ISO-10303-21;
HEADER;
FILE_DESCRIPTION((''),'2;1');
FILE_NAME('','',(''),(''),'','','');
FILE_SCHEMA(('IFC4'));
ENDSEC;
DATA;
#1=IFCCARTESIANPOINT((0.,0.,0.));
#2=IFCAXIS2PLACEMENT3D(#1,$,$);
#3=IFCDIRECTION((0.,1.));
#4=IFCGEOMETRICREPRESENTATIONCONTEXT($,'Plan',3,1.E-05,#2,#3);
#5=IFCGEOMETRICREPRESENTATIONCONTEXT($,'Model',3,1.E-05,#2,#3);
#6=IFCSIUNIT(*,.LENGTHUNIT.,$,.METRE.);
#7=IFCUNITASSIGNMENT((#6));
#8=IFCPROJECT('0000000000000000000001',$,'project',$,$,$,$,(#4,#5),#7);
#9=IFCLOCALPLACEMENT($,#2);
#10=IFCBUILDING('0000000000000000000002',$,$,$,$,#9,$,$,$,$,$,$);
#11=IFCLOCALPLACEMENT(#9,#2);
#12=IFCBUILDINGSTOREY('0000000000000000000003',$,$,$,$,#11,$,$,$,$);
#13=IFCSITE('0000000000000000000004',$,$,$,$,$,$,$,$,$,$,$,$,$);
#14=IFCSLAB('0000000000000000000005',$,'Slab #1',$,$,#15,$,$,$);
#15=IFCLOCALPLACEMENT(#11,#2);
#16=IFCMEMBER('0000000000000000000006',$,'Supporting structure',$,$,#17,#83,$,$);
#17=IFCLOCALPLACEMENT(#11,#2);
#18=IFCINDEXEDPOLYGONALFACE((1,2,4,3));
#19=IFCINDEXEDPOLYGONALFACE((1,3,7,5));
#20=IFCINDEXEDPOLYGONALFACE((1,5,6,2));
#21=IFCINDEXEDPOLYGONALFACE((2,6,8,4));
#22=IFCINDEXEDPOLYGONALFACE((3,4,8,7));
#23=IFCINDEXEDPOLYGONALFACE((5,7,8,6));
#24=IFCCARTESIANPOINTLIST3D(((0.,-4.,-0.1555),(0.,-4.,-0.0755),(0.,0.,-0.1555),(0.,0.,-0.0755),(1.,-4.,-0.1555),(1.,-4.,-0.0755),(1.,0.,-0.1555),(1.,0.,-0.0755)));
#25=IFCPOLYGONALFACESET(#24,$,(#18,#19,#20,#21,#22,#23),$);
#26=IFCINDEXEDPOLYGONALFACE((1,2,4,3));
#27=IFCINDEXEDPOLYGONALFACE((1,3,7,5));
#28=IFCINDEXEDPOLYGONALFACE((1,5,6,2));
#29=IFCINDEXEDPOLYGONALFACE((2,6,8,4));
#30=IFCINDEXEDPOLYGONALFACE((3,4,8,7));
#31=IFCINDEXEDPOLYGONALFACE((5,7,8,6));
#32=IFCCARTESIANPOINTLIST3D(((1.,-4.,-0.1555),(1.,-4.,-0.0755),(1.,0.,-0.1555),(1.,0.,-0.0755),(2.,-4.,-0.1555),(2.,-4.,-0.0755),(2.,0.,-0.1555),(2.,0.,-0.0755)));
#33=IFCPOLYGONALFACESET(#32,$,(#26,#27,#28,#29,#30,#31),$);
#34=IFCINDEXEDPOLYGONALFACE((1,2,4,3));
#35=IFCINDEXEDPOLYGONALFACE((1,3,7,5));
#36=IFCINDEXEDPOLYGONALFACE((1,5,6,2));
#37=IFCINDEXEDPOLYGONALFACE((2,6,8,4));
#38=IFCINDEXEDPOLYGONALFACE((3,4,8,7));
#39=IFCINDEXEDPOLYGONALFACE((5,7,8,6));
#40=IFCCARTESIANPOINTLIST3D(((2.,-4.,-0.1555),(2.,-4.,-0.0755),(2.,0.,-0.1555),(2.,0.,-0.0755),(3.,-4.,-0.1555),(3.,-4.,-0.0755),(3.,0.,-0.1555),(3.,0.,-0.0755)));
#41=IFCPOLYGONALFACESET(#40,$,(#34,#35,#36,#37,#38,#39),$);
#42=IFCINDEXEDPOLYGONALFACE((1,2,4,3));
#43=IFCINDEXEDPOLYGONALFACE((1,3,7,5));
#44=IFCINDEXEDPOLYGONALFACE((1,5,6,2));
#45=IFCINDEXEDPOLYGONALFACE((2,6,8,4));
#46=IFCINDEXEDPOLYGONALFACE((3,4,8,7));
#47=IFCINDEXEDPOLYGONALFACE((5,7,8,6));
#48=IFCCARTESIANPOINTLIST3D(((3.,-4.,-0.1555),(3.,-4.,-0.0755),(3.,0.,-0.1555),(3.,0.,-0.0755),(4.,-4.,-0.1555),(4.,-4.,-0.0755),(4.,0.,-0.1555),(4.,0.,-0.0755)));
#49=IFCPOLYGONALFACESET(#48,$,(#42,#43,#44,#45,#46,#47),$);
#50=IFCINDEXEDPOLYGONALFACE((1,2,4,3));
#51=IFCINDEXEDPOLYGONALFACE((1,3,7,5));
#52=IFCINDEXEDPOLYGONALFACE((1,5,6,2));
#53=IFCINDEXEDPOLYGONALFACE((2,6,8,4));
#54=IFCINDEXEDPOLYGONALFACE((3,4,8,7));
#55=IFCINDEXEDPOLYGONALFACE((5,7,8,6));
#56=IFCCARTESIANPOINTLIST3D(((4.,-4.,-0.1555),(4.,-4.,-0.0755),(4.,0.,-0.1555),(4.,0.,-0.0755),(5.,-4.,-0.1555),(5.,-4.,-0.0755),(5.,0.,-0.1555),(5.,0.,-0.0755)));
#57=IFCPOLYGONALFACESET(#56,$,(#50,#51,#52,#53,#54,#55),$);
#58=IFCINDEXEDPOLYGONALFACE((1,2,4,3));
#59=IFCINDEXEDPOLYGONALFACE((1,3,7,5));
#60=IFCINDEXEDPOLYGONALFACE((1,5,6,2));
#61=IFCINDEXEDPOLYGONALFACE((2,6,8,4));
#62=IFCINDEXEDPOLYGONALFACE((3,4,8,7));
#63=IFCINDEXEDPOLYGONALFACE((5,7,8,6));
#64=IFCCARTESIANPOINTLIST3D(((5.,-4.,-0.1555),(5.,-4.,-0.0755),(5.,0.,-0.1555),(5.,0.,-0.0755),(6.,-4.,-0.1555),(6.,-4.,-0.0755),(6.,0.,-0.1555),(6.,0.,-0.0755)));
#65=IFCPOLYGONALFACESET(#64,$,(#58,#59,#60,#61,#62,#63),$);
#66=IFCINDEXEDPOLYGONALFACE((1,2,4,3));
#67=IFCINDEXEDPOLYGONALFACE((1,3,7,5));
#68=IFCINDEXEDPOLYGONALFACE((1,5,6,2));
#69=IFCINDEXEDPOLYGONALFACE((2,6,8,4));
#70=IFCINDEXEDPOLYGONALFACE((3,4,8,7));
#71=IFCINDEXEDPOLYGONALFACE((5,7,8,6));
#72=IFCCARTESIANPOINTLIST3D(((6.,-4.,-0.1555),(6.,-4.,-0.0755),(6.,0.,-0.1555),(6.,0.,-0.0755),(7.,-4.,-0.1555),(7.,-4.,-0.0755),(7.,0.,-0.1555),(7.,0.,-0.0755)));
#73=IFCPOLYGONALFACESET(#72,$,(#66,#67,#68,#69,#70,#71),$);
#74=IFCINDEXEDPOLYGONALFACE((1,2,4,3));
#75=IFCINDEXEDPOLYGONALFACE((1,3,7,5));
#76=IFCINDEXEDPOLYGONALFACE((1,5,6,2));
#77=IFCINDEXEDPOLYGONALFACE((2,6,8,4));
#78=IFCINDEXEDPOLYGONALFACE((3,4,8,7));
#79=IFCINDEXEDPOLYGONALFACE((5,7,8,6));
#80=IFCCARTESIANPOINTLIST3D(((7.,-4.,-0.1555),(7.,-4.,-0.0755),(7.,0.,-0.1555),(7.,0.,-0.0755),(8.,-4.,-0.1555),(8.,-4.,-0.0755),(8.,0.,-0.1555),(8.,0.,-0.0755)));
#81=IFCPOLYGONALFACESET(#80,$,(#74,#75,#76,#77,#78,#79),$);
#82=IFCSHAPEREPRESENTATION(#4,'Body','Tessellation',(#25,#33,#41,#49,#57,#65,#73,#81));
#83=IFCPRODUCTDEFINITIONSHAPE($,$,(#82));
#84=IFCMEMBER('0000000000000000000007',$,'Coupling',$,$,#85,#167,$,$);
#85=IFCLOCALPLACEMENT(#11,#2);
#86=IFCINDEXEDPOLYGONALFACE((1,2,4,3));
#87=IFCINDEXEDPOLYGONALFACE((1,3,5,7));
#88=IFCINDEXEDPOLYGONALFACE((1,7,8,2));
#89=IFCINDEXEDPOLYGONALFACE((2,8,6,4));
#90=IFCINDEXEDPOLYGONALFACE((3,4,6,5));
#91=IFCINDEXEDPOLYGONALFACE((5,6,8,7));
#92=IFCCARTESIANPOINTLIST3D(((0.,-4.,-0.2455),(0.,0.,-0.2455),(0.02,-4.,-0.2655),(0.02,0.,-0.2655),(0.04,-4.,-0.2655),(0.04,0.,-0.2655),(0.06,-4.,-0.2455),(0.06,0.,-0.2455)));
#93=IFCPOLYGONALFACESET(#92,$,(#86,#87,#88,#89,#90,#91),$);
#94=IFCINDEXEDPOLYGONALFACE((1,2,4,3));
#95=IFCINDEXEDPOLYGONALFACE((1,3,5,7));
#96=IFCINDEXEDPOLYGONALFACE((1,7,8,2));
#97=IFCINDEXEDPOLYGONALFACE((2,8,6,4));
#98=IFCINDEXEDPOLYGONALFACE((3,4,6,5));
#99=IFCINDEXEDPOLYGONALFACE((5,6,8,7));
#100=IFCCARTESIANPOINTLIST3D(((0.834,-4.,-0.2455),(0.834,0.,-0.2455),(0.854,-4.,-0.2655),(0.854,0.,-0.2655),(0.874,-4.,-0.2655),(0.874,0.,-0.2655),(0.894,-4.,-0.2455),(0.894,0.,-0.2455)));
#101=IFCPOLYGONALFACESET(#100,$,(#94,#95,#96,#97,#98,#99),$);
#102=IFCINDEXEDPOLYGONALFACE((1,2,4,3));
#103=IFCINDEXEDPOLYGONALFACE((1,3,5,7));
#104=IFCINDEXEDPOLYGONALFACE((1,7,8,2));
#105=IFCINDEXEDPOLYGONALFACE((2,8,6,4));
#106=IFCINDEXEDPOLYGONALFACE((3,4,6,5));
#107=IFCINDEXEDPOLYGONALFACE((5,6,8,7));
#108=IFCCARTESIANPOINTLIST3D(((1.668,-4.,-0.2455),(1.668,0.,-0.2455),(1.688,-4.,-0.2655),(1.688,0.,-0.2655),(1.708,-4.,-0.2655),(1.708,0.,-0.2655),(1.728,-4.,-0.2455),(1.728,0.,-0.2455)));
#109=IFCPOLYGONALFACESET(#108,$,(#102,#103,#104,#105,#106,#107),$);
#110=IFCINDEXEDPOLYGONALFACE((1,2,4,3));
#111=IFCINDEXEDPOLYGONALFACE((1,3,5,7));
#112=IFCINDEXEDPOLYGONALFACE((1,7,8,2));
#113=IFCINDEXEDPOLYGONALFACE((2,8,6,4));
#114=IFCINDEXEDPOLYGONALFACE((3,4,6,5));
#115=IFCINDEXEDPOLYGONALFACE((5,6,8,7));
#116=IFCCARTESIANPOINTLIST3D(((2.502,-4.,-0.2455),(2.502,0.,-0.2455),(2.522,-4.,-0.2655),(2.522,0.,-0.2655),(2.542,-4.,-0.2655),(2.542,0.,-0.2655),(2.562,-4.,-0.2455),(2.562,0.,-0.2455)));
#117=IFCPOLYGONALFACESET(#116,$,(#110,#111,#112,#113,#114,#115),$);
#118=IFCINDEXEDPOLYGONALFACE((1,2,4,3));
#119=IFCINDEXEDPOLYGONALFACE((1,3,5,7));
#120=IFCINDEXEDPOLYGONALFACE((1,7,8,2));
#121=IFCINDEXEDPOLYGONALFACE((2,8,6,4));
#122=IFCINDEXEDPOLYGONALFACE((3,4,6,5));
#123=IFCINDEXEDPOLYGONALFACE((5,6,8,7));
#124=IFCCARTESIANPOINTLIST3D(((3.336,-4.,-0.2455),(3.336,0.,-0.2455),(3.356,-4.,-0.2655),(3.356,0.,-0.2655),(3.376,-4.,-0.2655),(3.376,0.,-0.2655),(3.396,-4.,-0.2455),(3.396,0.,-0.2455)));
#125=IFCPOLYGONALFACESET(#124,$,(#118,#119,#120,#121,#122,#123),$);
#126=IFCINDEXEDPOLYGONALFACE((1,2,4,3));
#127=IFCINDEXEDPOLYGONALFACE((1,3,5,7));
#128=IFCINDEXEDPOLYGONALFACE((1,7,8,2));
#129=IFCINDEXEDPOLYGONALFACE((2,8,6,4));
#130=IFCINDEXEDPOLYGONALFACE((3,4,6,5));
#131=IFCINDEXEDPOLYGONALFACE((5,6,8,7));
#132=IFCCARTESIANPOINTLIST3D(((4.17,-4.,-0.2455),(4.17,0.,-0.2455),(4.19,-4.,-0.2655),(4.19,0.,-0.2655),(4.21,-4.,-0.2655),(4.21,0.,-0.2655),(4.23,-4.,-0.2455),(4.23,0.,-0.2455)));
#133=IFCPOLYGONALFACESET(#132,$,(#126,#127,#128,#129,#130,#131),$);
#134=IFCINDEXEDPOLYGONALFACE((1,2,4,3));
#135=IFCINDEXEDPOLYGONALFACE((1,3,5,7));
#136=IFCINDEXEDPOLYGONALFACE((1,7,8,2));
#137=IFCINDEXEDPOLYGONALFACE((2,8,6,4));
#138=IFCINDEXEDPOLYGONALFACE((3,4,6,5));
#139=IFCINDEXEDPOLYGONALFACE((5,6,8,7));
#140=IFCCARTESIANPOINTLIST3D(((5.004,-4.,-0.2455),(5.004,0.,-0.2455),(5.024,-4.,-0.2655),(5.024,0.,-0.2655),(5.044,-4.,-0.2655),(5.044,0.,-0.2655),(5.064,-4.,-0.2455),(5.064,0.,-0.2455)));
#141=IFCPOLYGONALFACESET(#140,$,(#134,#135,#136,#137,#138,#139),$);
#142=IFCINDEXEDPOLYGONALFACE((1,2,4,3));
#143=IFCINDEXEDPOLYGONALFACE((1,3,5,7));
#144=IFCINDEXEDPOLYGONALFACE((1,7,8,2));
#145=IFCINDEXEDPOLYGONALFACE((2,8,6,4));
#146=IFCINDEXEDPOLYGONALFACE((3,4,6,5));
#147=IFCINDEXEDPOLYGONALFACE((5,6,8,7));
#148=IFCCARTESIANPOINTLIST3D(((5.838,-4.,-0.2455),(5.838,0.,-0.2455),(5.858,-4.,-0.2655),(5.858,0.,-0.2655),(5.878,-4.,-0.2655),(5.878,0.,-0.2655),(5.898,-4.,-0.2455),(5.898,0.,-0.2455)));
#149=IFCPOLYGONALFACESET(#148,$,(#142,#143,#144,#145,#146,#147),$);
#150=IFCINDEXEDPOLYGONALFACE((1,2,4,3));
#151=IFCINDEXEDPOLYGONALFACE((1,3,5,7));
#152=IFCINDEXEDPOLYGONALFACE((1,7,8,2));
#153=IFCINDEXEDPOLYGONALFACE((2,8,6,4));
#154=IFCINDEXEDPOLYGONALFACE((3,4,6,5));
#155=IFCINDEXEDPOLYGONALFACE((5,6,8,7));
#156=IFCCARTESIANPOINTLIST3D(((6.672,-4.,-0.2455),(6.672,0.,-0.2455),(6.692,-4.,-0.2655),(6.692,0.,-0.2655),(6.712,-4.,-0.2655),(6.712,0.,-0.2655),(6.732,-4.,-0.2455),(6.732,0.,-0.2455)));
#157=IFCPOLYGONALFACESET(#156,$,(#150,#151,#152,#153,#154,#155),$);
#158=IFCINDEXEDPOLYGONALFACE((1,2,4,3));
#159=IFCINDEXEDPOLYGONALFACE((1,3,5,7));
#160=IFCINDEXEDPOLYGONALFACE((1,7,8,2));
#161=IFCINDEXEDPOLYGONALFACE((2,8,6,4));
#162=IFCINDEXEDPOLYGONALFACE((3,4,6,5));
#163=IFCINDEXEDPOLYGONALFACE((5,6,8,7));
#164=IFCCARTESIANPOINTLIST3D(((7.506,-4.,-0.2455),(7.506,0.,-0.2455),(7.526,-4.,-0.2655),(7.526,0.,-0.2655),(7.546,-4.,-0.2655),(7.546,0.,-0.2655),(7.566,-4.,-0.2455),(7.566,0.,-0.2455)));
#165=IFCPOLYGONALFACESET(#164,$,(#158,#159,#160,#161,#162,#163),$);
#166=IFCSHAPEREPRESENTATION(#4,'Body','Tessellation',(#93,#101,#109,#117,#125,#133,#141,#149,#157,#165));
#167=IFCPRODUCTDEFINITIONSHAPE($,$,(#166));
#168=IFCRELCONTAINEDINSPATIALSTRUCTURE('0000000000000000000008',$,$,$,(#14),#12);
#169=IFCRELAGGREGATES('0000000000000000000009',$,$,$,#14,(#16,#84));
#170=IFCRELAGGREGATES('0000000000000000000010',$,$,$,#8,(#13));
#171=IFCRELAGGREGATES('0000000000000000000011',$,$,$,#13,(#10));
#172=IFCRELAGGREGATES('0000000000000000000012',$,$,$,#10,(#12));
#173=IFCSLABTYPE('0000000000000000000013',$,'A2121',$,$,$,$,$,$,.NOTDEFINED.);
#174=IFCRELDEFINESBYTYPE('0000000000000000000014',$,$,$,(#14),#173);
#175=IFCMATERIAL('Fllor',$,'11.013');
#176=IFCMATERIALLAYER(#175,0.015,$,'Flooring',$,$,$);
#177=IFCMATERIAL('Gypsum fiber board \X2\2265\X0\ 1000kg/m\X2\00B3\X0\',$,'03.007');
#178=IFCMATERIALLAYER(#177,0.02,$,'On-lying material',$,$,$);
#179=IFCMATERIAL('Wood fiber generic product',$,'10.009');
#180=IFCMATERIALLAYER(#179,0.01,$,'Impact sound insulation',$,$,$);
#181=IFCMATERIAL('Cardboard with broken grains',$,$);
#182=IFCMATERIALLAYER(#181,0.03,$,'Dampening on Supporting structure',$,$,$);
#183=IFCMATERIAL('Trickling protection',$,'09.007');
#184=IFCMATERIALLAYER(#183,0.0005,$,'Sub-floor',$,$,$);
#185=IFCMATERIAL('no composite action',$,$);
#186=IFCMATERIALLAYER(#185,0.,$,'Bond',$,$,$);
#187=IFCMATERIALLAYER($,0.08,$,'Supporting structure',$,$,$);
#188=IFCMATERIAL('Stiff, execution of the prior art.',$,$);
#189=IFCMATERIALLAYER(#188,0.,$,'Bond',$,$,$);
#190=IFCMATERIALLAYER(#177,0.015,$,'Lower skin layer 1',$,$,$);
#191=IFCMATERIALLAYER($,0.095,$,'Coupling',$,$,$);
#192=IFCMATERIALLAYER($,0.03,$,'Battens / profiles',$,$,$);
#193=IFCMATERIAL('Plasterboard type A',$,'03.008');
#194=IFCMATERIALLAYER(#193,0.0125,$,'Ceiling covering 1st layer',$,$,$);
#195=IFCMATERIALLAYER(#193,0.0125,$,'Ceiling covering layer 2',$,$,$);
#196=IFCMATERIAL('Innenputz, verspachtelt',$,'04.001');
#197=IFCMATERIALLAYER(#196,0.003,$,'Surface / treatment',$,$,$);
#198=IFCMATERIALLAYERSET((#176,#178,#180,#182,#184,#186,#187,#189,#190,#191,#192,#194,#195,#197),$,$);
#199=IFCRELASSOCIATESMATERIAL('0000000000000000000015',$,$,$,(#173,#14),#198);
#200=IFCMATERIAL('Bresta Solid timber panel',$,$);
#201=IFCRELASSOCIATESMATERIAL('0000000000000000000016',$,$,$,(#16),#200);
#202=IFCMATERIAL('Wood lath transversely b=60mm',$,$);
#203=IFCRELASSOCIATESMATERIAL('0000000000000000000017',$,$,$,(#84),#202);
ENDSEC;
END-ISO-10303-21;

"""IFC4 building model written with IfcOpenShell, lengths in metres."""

from ifc_helpers import new_model, si_unit, direction, frame, frame_2d, origin, place, context, project, spatial, polyline, rectangle, outline, extrude, material, layer, layer_set, type_object, element, aggregate, save


model = new_model("IFC4")

# Units and contexts
plan_context = context("Plan", 3, precision=1e-05, world=origin(), true_north=direction((0.0, 1.0)))
model_context = context("Model", 3, precision=1e-05, world=origin(), true_north=direction((0.0, 1.0)))
ifc_project = project(units=[si_unit("LENGTHUNIT", "METRE")], contexts=[plan_context, model_context])

# Site, building, storey
site = spatial("IfcSite", under=ifc_project)
building_placement = place(None, origin())
building = spatial("IfcBuilding", under=site, at=building_placement)
storey_placement = place(building_placement, origin())
storey = spatial("IfcBuildingStorey", under=building, at=storey_placement)

# Slab, members
ifc_material_1 = material(Name="Fllor", Category="11.013")
ifc_layer_1 = layer(ifc_material_1, 0.015, Name="Flooring")
ifc_material_2 = material(Name="Gypsum fiber board ≥ 1000kg/m³", Category="03.007")
ifc_layer_2 = layer(ifc_material_2, 0.02, Name="On-lying material")
ifc_material_3 = material(Name="Wood fiber generic product", Category="10.009")
ifc_layer_3 = layer(ifc_material_3, 0.01, Name="Impact sound insulation")
ifc_material_4 = material(Name="Cardboard with broken grains")
ifc_layer_4 = layer(ifc_material_4, 0.03, Name="Dampening on Supporting structure")
ifc_material_5 = material(Name="Trickling protection", Category="09.007")
ifc_layer_5 = layer(ifc_material_5, 0.0005, Name="Sub-floor")
ifc_material_6 = material(Name="no composite action")
ifc_layer_6 = layer(ifc_material_6, 0.0, Name="Bond")
ifc_layer_7 = layer(None, 0.08, Name="Supporting structure")
ifc_material_7 = material(Name="Stiff, execution of the prior art.")
ifc_layer_8 = layer(ifc_material_7, 0.0, Name="Bond")
ifc_layer_9 = layer(ifc_material_2, 0.015, Name="Lower skin layer 1")
ifc_layer_10 = layer(None, 0.095, Name="Coupling")
ifc_layer_11 = layer(None, 0.03, Name="Battens / profiles")
ifc_material_8 = material(Name="Plasterboard type A", Category="03.008")
ifc_layer_12 = layer(ifc_material_8, 0.0125, Name="Ceiling covering 1st layer")
ifc_layer_13 = layer(ifc_material_8, 0.0125, Name="Ceiling covering layer 2")
ifc_material_9 = material(Name="Innenputz, verspachtelt", Category="04.001")
ifc_layer_14 = layer(ifc_material_9, 0.003, Name="Surface / treatment")
ifc_layer_set = layer_set([ifc_layer_1, ifc_layer_2, ifc_layer_3, ifc_layer_4, ifc_layer_5, ifc_layer_6, ifc_layer_7, ifc_layer_8, ifc_layer_9, ifc_layer_10, ifc_layer_11, ifc_layer_12, ifc_layer_13, ifc_layer_14])
slab_type = type_object("IfcSlabType", Name="A2121", PredefinedType="NOTDEFINED", material=ifc_layer_set)
slab_placement = place(None, frame((0.0, 0.0, 0.0), z_axis=(0.0, 0.0, -1.0), x_axis=(1.0, 0.0, 0.0)))
slab = element("IfcSlab", 1, at=slab_placement, inside=storey, type_object=slab_type, material=ifc_layer_set, Name="Slab #1")
ifc_material_10 = material(Name="Bresta Solid timber panel")
member_1_placement = place(slab_placement, origin())
member_1 = element("IfcMember", 2, at=member_1_placement, material=ifc_material_10, Name="Supporting structure", context=plan_context, shape_type="SweptSolid", body=[
    extrude(rectangle(XDim=1.0, YDim=0.08, at=frame_2d((0.5, 0.04), x_axis=(1.0, 0.0))), frame((0.0, 4.0, 0.0755), z_axis=(0.0, -1.0, 0.0), x_axis=(1.0, 0.0, 0.0)), (0.0, 0.0, 1.0), 4.0),
    extrude(rectangle(XDim=1.0, YDim=0.08, at=frame_2d((0.5, 0.04), x_axis=(1.0, 0.0))), frame((1.0, 4.0, 0.0755), z_axis=(0.0, -1.0, 0.0), x_axis=(1.0, 0.0, 0.0)), (0.0, 0.0, 1.0), 4.0),
    extrude(rectangle(XDim=1.0, YDim=0.08, at=frame_2d((0.5, 0.04), x_axis=(1.0, 0.0))), frame((2.0, 4.0, 0.0755), z_axis=(0.0, -1.0, 0.0), x_axis=(1.0, 0.0, 0.0)), (0.0, 0.0, 1.0), 4.0),
    extrude(rectangle(XDim=1.0, YDim=0.08, at=frame_2d((0.5, 0.04), x_axis=(1.0, 0.0))), frame((3.0, 4.0, 0.0755), z_axis=(0.0, -1.0, 0.0), x_axis=(1.0, 0.0, 0.0)), (0.0, 0.0, 1.0), 4.0),
    extrude(rectangle(XDim=1.0, YDim=0.08, at=frame_2d((0.5, 0.04), x_axis=(1.0, 0.0))), frame((4.0, 4.0, 0.0755), z_axis=(0.0, -1.0, 0.0), x_axis=(1.0, 0.0, 0.0)), (0.0, 0.0, 1.0), 4.0),
    extrude(rectangle(XDim=1.0, YDim=0.08, at=frame_2d((0.5, 0.04), x_axis=(1.0, 0.0))), frame((5.0, 4.0, 0.0755), z_axis=(0.0, -1.0, 0.0), x_axis=(1.0, 0.0, 0.0)), (0.0, 0.0, 1.0), 4.0),
    extrude(rectangle(XDim=1.0, YDim=0.08, at=frame_2d((0.5, 0.04), x_axis=(1.0, 0.0))), frame((6.0, 4.0, 0.0755), z_axis=(0.0, -1.0, 0.0), x_axis=(1.0, 0.0, 0.0)), (0.0, 0.0, 1.0), 4.0),
    extrude(rectangle(XDim=1.0, YDim=0.08, at=frame_2d((0.5, 0.04), x_axis=(1.0, 0.0))), frame((7.0, 4.0, 0.0755), z_axis=(0.0, -1.0, 0.0), x_axis=(1.0, 0.0, 0.0)), (0.0, 0.0, 1.0), 4.0),
])
ifc_material_11 = material(Name="Wood lath transversely b=60mm")
member_2_placement = place(slab_placement, origin())
member_2 = element("IfcMember", 3, at=member_2_placement, material=ifc_material_11, Name="Coupling", context=plan_context, shape_type="SweptSolid", body=[
    extrude(outline(polyline([(0.0, 0.0), (0.06, 0.0), (0.04, 0.02), (0.02, 0.02), (0.0, 0.0)])), frame((0.0, 4.0, 0.2455), z_axis=(0.0, -1.0, 0.0), x_axis=(1.0, 0.0, 0.0)), (0.0, 0.0, 1.0), 4.0),
    extrude(outline(polyline([(0.0, 0.0), (0.06, 0.0), (0.04, 0.02), (0.02, 0.02), (0.0, 0.0)])), frame((0.834, 4.0, 0.2455), z_axis=(0.0, -1.0, 0.0), x_axis=(1.0, 0.0, 0.0)), (0.0, 0.0, 1.0), 4.0),
    extrude(outline(polyline([(0.0, 0.0), (0.06, 0.0), (0.04, 0.02), (0.02, 0.02), (0.0, 0.0)])), frame((1.668, 4.0, 0.2455), z_axis=(0.0, -1.0, 0.0), x_axis=(1.0, 0.0, 0.0)), (0.0, 0.0, 1.0), 4.0),
    extrude(outline(polyline([(0.0, 0.0), (0.06, 0.0), (0.04, 0.02), (0.02, 0.02), (0.0, 0.0)])), frame((2.502, 4.0, 0.2455), z_axis=(0.0, -1.0, 0.0), x_axis=(1.0, 0.0, 0.0)), (0.0, 0.0, 1.0), 4.0),
    extrude(outline(polyline([(0.0, 0.0), (0.06, 0.0), (0.04, 0.02), (0.02, 0.02), (0.0, 0.0)])), frame((3.336, 4.0, 0.2455), z_axis=(0.0, -1.0, 0.0), x_axis=(1.0, 0.0, 0.0)), (0.0, 0.0, 1.0), 4.0),
    extrude(outline(polyline([(0.0, 0.0), (0.06, 0.0), (0.04, 0.02), (0.02, 0.02), (0.0, 0.0)])), frame((4.17, 4.0, 0.2455), z_axis=(0.0, -1.0, 0.0), x_axis=(1.0, 0.0, 0.0)), (0.0, 0.0, 1.0), 4.0),
    extrude(outline(polyline([(0.0, 0.0), (0.06, 0.0), (0.04, 0.02), (0.02, 0.02), (0.0, 0.0)])), frame((5.004, 4.0, 0.2455), z_axis=(0.0, -1.0, 0.0), x_axis=(1.0, 0.0, 0.0)), (0.0, 0.0, 1.0), 4.0),
    extrude(outline(polyline([(0.0, 0.0), (0.06, 0.0), (0.04, 0.02), (0.02, 0.02), (0.0, 0.0)])), frame((5.838, 4.0, 0.2455), z_axis=(0.0, -1.0, 0.0), x_axis=(1.0, 0.0, 0.0)), (0.0, 0.0, 1.0), 4.0),
    extrude(outline(polyline([(0.0, 0.0), (0.06, 0.0), (0.04, 0.02), (0.02, 0.02), (0.0, 0.0)])), frame((6.672, 4.0, 0.2455), z_axis=(0.0, -1.0, 0.0), x_axis=(1.0, 0.0, 0.0)), (0.0, 0.0, 1.0), 4.0),
    extrude(outline(polyline([(0.0, 0.0), (0.06, 0.0), (0.04, 0.02), (0.02, 0.02), (0.0, 0.0)])), frame((7.506, 4.0, 0.2455), z_axis=(0.0, -1.0, 0.0), x_axis=(1.0, 0.0, 0.0)), (0.0, 0.0, 1.0), 4.0),
])
aggregate(slab, [member_1, member_2])

save(model, "model.ifc")
